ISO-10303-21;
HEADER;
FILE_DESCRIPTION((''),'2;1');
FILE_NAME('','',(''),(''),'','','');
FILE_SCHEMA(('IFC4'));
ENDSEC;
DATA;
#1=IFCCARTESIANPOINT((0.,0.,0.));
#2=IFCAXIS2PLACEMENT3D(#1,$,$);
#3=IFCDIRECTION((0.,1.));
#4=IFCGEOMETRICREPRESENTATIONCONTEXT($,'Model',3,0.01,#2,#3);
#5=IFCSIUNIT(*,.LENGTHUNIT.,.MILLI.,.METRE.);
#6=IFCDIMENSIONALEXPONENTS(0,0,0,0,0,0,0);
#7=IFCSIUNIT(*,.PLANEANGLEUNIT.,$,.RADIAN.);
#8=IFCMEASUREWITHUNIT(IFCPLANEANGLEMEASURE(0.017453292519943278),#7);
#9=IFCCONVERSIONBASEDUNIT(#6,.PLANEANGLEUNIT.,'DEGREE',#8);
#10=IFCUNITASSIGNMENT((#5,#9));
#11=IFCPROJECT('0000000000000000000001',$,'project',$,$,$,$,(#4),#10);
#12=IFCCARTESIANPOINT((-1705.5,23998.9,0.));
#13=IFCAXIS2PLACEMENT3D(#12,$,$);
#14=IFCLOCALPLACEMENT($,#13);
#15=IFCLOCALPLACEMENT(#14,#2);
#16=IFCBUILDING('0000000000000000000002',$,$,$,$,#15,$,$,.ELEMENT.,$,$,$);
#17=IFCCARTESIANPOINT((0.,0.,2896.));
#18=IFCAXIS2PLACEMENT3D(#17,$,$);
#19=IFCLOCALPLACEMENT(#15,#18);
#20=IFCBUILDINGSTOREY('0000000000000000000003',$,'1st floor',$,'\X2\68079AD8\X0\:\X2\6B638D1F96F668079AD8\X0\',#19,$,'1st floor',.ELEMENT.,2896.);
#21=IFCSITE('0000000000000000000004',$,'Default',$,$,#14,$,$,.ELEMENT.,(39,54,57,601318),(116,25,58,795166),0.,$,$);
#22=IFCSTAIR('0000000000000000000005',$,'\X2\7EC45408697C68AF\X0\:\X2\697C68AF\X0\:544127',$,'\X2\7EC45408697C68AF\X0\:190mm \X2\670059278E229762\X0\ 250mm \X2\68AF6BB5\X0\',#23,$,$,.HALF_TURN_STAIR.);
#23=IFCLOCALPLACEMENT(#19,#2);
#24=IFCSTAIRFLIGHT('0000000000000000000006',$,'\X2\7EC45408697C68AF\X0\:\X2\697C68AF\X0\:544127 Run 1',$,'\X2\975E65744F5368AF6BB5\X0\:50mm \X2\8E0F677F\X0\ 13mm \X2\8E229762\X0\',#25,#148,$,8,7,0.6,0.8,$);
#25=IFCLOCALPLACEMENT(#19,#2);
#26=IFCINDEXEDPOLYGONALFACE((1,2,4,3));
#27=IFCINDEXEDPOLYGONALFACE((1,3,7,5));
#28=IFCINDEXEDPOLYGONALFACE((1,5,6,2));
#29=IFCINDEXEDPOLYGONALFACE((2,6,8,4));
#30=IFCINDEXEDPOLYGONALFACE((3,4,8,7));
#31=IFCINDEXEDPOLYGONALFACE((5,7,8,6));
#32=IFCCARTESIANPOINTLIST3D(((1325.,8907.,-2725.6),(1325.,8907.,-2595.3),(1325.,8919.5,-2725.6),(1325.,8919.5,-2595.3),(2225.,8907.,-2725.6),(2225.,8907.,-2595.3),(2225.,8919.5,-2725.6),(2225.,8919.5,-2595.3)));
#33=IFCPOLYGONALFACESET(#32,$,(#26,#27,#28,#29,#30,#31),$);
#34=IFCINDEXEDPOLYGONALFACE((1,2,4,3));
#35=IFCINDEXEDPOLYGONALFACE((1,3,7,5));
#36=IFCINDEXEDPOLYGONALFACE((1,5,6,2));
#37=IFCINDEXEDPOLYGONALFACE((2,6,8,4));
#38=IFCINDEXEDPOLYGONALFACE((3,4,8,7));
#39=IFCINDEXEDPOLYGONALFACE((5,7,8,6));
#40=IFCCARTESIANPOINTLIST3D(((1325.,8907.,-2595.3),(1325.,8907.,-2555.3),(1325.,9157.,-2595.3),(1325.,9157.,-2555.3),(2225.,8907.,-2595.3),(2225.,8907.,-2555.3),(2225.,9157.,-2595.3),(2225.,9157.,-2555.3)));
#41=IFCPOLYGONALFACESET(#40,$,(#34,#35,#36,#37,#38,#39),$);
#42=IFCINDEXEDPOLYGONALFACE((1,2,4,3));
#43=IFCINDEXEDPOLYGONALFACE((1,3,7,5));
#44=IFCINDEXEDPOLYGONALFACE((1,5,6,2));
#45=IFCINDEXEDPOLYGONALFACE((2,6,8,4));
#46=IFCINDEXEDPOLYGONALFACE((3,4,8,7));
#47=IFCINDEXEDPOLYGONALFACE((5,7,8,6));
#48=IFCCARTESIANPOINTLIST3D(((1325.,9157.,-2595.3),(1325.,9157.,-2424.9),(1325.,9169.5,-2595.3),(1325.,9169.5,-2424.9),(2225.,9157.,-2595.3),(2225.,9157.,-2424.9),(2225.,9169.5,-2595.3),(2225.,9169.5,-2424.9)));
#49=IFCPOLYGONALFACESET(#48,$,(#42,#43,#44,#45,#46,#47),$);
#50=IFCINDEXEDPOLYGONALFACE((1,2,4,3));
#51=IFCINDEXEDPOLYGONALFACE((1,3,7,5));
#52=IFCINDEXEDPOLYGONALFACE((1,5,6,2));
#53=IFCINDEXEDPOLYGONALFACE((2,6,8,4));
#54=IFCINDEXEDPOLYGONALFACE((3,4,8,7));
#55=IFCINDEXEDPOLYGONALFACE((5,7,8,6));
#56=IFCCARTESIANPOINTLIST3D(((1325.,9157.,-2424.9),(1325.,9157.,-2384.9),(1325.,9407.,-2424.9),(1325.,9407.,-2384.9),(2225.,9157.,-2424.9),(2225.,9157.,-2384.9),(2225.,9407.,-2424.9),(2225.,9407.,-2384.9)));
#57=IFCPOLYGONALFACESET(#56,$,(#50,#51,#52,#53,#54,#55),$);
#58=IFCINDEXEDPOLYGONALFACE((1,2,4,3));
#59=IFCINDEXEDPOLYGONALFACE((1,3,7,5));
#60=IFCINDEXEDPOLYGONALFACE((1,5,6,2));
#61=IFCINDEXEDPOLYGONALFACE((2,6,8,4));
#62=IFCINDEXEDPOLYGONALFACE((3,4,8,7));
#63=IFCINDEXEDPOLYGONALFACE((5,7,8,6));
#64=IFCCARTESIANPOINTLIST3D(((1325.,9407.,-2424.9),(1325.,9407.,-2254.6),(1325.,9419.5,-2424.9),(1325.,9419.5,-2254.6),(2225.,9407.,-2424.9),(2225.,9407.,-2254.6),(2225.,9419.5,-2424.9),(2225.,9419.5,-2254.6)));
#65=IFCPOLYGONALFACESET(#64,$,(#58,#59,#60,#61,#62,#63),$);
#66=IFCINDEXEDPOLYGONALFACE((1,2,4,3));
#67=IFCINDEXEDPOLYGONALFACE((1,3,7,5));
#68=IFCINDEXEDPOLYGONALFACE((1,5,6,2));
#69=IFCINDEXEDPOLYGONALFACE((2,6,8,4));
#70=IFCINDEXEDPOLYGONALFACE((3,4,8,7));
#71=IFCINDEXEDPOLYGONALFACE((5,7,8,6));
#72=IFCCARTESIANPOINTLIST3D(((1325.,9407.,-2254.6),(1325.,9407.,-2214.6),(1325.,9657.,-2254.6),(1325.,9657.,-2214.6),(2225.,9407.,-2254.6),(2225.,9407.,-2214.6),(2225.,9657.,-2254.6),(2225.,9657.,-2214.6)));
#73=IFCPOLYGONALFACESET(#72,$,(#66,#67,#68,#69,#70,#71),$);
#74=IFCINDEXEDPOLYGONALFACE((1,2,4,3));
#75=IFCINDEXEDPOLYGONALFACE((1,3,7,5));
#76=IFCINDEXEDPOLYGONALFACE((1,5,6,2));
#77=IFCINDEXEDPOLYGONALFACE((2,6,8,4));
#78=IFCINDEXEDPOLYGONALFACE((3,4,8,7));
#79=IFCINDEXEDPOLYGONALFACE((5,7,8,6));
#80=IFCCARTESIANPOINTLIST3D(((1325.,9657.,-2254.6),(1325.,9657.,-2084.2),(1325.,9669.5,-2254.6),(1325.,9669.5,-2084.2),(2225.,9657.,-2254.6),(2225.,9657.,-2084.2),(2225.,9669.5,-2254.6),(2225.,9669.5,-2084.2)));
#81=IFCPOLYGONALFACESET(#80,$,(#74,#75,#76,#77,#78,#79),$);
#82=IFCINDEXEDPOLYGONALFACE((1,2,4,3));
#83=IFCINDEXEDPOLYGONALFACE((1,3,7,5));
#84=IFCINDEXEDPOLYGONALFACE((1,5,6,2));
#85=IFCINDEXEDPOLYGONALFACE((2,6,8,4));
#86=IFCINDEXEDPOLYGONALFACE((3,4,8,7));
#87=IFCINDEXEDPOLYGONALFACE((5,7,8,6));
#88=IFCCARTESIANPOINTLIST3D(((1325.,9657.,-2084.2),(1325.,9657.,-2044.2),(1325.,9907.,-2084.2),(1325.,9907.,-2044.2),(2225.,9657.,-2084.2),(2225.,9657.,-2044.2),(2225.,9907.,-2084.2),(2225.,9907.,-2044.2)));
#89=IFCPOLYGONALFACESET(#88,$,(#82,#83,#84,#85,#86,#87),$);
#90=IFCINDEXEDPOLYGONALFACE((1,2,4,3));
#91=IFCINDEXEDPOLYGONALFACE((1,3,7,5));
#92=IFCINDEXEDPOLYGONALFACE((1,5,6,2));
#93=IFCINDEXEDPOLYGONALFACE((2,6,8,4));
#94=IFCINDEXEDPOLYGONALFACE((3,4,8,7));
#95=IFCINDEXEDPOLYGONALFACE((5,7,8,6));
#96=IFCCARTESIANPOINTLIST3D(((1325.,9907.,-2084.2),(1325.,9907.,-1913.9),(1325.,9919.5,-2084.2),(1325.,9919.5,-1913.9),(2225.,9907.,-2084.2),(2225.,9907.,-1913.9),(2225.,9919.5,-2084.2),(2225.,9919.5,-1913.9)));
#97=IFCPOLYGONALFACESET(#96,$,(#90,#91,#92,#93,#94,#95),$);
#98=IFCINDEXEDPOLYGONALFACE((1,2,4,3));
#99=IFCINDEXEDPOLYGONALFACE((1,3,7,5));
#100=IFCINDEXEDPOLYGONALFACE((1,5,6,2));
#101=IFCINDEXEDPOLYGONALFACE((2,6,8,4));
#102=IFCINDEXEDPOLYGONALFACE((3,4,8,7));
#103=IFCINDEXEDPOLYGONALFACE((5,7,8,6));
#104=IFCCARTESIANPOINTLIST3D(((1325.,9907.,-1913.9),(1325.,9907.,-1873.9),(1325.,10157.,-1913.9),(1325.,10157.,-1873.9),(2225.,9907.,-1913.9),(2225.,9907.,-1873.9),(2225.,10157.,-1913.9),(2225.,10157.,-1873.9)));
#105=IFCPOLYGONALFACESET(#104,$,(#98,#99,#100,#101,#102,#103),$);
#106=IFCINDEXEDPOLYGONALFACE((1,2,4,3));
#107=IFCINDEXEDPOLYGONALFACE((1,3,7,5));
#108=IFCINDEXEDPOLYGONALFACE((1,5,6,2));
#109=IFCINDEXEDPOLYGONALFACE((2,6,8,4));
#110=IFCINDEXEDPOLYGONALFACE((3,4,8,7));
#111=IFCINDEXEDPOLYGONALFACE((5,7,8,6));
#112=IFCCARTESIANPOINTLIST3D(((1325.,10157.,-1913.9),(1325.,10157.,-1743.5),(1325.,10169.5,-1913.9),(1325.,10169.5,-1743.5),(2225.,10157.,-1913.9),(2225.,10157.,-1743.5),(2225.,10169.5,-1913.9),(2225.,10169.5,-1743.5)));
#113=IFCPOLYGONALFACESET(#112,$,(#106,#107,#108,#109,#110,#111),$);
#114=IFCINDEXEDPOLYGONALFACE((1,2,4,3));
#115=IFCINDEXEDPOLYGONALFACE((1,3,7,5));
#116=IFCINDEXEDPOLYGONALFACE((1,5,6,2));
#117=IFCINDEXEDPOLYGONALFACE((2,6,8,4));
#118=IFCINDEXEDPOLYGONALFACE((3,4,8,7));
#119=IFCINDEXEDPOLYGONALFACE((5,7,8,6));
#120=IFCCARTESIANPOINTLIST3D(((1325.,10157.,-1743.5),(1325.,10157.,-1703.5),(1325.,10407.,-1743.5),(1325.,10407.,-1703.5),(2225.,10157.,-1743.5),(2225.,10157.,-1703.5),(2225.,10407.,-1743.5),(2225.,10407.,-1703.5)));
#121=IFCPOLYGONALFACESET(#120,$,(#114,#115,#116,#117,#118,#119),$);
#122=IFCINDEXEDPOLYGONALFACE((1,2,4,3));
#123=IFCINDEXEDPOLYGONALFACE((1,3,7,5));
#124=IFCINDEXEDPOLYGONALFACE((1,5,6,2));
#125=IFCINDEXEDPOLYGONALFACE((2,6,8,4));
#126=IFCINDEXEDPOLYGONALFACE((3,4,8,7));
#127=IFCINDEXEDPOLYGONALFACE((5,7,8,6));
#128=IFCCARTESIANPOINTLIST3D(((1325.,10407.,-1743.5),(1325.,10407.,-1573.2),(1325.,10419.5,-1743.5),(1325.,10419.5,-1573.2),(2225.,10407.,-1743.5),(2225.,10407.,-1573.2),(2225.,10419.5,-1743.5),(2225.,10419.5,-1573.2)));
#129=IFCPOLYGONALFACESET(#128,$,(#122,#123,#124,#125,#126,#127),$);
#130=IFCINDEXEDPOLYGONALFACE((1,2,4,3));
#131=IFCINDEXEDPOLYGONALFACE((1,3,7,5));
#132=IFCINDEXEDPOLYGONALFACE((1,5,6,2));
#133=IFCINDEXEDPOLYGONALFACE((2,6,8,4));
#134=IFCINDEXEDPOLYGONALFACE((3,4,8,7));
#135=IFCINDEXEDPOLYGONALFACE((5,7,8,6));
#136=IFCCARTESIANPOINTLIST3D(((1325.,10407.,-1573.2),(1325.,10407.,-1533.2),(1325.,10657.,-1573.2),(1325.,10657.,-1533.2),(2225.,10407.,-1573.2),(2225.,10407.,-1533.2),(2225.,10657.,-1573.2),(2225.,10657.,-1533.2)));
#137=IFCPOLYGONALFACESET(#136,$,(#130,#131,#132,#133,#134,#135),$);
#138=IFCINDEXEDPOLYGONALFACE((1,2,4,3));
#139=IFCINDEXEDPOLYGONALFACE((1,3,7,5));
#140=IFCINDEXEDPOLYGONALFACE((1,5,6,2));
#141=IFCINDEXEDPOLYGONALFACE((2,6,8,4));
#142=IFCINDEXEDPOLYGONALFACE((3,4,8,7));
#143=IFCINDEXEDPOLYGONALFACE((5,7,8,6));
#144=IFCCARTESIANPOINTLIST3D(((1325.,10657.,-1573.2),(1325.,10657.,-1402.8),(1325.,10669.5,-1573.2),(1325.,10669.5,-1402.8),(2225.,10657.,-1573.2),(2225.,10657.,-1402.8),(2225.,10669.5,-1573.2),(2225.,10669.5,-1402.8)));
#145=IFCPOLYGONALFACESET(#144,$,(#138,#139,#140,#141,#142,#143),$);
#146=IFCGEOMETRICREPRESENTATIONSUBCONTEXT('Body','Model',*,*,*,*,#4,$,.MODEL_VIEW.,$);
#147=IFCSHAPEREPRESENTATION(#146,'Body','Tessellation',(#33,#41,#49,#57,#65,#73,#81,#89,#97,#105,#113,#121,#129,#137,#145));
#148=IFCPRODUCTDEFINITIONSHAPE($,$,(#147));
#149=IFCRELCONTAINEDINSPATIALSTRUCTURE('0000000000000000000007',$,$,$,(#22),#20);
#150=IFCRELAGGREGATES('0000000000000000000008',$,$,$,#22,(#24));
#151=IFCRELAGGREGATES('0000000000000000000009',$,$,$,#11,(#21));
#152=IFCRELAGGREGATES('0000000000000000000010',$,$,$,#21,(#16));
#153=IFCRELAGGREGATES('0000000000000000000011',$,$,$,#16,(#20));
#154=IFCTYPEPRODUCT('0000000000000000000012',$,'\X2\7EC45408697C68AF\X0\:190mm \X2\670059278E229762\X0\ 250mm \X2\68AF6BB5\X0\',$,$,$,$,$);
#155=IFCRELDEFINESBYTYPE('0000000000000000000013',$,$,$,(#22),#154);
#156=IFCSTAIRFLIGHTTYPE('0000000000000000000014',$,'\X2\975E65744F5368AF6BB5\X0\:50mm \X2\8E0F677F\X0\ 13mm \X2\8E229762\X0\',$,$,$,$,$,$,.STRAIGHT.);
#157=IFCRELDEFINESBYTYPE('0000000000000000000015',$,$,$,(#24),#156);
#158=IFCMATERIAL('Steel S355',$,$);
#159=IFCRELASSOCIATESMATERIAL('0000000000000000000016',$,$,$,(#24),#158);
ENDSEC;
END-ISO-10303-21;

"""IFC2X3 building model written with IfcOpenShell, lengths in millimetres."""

from ifc_helpers import new_model, entity, si_unit, converted_unit, direction, frame, frame_2d, origin, origin_2d_with_axis, place, context, subcontext, project, spatial, rectangle, extrude, material, type_object, element, aggregate, save


model = new_model("IFC2X3")

# Units and contexts
model_context = context("Model", 3, precision=0.01, world=origin(), true_north=direction((0.0, 1.0)))
body_context = subcontext(model_context, "Body", "Model", "MODEL_VIEW")
ifc_project = project(units=[si_unit("LENGTHUNIT", "METRE", prefix="MILLI"), converted_unit("PLANEANGLEUNIT", "DEGREE", entity("IfcPlaneAngleMeasure", 0.017453292519943278), si_unit("PLANEANGLEUNIT", "RADIAN"), dimensions=[0, 0, 0, 0, 0, 0, 0])], contexts=[model_context])

# Site, building, storey
site_placement = place(None, frame((-1705.5, 23998.9, 0.0)))
site = spatial("IfcSite", under=ifc_project, at=site_placement, Name="Default", CompositionType="ELEMENT", RefLatitude=(39, 54, 57, 601318), RefLongitude=(116, 25, 58, 795166), RefElevation=0.0)
building_placement = place(site_placement, origin())
building = spatial("IfcBuilding", under=site, at=building_placement, CompositionType="ELEMENT")
storey_placement = place(building_placement, frame((0.0, 0.0, 2896.0)))
storey = spatial("IfcBuildingStorey", under=building, at=storey_placement, Name="1st floor", ObjectType="标高:正负零标高", LongName="1st floor", CompositionType="ELEMENT", Elevation=2896.0)

# Shared definitions
ifc_material_1 = material(Name="Steel S355")

# Stair
type_product = type_object("IfcTypeProduct", Name="组合楼梯:190mm 最大踢面 250mm 梯段")
stair_placement = place(storey_placement, origin())
stair = element("IfcStair", 1, at=stair_placement, inside=storey, type_object=type_product, Name="组合楼梯:楼梯:544127", ObjectType="组合楼梯:190mm 最大踢面 250mm 梯段", ShapeType="HALF_TURN_STAIR")

# Stair flight
stair_flight_type = type_object("IfcStairFlightType", Name="非整体梯段:50mm 踏板 13mm 踢面", PredefinedType="STRAIGHT")
stair_flight_1_placement = place(stair_placement, origin())
stair_flight_1 = element("IfcStairFlight", 2, at=stair_flight_1_placement, type_object=stair_flight_type, material=ifc_material_1, Name="组合楼梯:楼梯:544127 Run 1", ObjectType="非整体梯段:50mm 踏板 13mm 踢面", NumberOfRiser=8, NumberOfTreads=7, RiserHeight=0.6, TreadLength=0.8, context=body_context, shape_type="SweptSolid", body=[
    extrude(rectangle(XDim=900.0, YDim=12.5, at=origin_2d_with_axis()), frame((1775.0, 8913.2, -2725.6), z_axis=(0.0, 0.0, 1.0), x_axis=(-1.0, 0.0, 0.0)), (0.0, 0.0, 1.0), 130.4),
    extrude(rectangle(XDim=250.0, YDim=900.0, at=frame_2d((0.0, 0.0), x_axis=(1.0, 0.0))), frame((1775.0, 9032.0, -2595.3), z_axis=(0.0, 0.0, 1.0), x_axis=(0.0, -1.0, 0.0)), (0.0, 0.0, 1.0), 40.0),
    extrude(rectangle(XDim=900.0, YDim=12.5, at=frame_2d((0.0, 0.0), x_axis=(1.0, 0.0))), frame((1775.0, 9163.2, -2595.3), z_axis=(0.0, 0.0, 1.0), x_axis=(-1.0, 0.0, 0.0)), (0.0, 0.0, 1.0), 170.4),
    extrude(rectangle(XDim=250.0, YDim=900.0, at=frame_2d((0.0, 0.0), x_axis=(1.0, 0.0))), frame((1775.0, 9282.0, -2424.9), z_axis=(0.0, 0.0, 1.0), x_axis=(0.0, -1.0, 0.0)), (0.0, 0.0, 1.0), 40.0),
    extrude(rectangle(XDim=900.0, YDim=12.5, at=frame_2d((0.0, 0.0), x_axis=(1.0, 0.0))), frame((1775.0, 9413.2, -2424.9), z_axis=(0.0, 0.0, 1.0), x_axis=(-1.0, 0.0, 0.0)), (0.0, 0.0, 1.0), 170.4),
    extrude(rectangle(XDim=250.0, YDim=900.0, at=frame_2d((0.0, 0.0), x_axis=(1.0, 0.0))), frame((1775.0, 9532.0, -2254.6), z_axis=(0.0, 0.0, 1.0), x_axis=(0.0, -1.0, 0.0)), (0.0, 0.0, 1.0), 40.0),
    extrude(rectangle(XDim=900.0, YDim=12.5, at=frame_2d((0.0, 0.0), x_axis=(1.0, 0.0))), frame((1775.0, 9663.2, -2254.6), z_axis=(0.0, 0.0, 1.0), x_axis=(-1.0, 0.0, 0.0)), (0.0, 0.0, 1.0), 170.4),
    extrude(rectangle(XDim=250.0, YDim=900.0, at=frame_2d((0.0, 0.0), x_axis=(1.0, 0.0))), frame((1775.0, 9782.0, -2084.2), z_axis=(0.0, 0.0, 1.0), x_axis=(0.0, -1.0, 0.0)), (0.0, 0.0, 1.0), 40.0),
    extrude(rectangle(XDim=900.0, YDim=12.5, at=origin_2d_with_axis()), frame((1775.0, 9913.2, -2084.2), z_axis=(0.0, 0.0, 1.0), x_axis=(-1.0, 0.0, 0.0)), (0.0, 0.0, 1.0), 170.4),
    extrude(rectangle(XDim=250.0, YDim=900.0, at=frame_2d((0.0, 0.0), x_axis=(1.0, 0.0))), frame((1775.0, 10032.0, -1913.9), z_axis=(0.0, 0.0, 1.0), x_axis=(0.0, -1.0, 0.0)), (0.0, 0.0, 1.0), 40.0),
    extrude(rectangle(XDim=900.0, YDim=12.5, at=origin_2d_with_axis()), frame((1775.0, 10163.2, -1913.9), z_axis=(0.0, 0.0, 1.0), x_axis=(-1.0, 0.0, 0.0)), (0.0, 0.0, 1.0), 170.4),
    extrude(rectangle(XDim=250.0, YDim=900.0, at=origin_2d_with_axis()), frame((1775.0, 10282.0, -1743.5), z_axis=(0.0, 0.0, 1.0), x_axis=(0.0, -1.0, 0.0)), (0.0, 0.0, 1.0), 40.0),
    extrude(rectangle(XDim=900.0, YDim=12.5, at=origin_2d_with_axis()), frame((1775.0, 10413.2, -1743.5), z_axis=(0.0, 0.0, 1.0), x_axis=(-1.0, 0.0, 0.0)), (0.0, 0.0, 1.0), 170.4),
    extrude(rectangle(XDim=250.0, YDim=900.0, at=origin_2d_with_axis()), frame((1775.0, 10532.0, -1573.2), z_axis=(0.0, 0.0, 1.0), x_axis=(0.0, -1.0, 0.0)), (0.0, 0.0, 1.0), 40.0),
    extrude(rectangle(XDim=900.0, YDim=12.5, at=frame_2d((0.0, 0.0), x_axis=(1.0, 0.0))), frame((1775.0, 10663.2, -1573.2), z_axis=(0.0, 0.0, 1.0), x_axis=(-1.0, 0.0, 0.0)), (0.0, 0.0, 1.0), 170.4),
])
aggregate(stair, [stair_flight_1])

save(model, "model.ifc")
